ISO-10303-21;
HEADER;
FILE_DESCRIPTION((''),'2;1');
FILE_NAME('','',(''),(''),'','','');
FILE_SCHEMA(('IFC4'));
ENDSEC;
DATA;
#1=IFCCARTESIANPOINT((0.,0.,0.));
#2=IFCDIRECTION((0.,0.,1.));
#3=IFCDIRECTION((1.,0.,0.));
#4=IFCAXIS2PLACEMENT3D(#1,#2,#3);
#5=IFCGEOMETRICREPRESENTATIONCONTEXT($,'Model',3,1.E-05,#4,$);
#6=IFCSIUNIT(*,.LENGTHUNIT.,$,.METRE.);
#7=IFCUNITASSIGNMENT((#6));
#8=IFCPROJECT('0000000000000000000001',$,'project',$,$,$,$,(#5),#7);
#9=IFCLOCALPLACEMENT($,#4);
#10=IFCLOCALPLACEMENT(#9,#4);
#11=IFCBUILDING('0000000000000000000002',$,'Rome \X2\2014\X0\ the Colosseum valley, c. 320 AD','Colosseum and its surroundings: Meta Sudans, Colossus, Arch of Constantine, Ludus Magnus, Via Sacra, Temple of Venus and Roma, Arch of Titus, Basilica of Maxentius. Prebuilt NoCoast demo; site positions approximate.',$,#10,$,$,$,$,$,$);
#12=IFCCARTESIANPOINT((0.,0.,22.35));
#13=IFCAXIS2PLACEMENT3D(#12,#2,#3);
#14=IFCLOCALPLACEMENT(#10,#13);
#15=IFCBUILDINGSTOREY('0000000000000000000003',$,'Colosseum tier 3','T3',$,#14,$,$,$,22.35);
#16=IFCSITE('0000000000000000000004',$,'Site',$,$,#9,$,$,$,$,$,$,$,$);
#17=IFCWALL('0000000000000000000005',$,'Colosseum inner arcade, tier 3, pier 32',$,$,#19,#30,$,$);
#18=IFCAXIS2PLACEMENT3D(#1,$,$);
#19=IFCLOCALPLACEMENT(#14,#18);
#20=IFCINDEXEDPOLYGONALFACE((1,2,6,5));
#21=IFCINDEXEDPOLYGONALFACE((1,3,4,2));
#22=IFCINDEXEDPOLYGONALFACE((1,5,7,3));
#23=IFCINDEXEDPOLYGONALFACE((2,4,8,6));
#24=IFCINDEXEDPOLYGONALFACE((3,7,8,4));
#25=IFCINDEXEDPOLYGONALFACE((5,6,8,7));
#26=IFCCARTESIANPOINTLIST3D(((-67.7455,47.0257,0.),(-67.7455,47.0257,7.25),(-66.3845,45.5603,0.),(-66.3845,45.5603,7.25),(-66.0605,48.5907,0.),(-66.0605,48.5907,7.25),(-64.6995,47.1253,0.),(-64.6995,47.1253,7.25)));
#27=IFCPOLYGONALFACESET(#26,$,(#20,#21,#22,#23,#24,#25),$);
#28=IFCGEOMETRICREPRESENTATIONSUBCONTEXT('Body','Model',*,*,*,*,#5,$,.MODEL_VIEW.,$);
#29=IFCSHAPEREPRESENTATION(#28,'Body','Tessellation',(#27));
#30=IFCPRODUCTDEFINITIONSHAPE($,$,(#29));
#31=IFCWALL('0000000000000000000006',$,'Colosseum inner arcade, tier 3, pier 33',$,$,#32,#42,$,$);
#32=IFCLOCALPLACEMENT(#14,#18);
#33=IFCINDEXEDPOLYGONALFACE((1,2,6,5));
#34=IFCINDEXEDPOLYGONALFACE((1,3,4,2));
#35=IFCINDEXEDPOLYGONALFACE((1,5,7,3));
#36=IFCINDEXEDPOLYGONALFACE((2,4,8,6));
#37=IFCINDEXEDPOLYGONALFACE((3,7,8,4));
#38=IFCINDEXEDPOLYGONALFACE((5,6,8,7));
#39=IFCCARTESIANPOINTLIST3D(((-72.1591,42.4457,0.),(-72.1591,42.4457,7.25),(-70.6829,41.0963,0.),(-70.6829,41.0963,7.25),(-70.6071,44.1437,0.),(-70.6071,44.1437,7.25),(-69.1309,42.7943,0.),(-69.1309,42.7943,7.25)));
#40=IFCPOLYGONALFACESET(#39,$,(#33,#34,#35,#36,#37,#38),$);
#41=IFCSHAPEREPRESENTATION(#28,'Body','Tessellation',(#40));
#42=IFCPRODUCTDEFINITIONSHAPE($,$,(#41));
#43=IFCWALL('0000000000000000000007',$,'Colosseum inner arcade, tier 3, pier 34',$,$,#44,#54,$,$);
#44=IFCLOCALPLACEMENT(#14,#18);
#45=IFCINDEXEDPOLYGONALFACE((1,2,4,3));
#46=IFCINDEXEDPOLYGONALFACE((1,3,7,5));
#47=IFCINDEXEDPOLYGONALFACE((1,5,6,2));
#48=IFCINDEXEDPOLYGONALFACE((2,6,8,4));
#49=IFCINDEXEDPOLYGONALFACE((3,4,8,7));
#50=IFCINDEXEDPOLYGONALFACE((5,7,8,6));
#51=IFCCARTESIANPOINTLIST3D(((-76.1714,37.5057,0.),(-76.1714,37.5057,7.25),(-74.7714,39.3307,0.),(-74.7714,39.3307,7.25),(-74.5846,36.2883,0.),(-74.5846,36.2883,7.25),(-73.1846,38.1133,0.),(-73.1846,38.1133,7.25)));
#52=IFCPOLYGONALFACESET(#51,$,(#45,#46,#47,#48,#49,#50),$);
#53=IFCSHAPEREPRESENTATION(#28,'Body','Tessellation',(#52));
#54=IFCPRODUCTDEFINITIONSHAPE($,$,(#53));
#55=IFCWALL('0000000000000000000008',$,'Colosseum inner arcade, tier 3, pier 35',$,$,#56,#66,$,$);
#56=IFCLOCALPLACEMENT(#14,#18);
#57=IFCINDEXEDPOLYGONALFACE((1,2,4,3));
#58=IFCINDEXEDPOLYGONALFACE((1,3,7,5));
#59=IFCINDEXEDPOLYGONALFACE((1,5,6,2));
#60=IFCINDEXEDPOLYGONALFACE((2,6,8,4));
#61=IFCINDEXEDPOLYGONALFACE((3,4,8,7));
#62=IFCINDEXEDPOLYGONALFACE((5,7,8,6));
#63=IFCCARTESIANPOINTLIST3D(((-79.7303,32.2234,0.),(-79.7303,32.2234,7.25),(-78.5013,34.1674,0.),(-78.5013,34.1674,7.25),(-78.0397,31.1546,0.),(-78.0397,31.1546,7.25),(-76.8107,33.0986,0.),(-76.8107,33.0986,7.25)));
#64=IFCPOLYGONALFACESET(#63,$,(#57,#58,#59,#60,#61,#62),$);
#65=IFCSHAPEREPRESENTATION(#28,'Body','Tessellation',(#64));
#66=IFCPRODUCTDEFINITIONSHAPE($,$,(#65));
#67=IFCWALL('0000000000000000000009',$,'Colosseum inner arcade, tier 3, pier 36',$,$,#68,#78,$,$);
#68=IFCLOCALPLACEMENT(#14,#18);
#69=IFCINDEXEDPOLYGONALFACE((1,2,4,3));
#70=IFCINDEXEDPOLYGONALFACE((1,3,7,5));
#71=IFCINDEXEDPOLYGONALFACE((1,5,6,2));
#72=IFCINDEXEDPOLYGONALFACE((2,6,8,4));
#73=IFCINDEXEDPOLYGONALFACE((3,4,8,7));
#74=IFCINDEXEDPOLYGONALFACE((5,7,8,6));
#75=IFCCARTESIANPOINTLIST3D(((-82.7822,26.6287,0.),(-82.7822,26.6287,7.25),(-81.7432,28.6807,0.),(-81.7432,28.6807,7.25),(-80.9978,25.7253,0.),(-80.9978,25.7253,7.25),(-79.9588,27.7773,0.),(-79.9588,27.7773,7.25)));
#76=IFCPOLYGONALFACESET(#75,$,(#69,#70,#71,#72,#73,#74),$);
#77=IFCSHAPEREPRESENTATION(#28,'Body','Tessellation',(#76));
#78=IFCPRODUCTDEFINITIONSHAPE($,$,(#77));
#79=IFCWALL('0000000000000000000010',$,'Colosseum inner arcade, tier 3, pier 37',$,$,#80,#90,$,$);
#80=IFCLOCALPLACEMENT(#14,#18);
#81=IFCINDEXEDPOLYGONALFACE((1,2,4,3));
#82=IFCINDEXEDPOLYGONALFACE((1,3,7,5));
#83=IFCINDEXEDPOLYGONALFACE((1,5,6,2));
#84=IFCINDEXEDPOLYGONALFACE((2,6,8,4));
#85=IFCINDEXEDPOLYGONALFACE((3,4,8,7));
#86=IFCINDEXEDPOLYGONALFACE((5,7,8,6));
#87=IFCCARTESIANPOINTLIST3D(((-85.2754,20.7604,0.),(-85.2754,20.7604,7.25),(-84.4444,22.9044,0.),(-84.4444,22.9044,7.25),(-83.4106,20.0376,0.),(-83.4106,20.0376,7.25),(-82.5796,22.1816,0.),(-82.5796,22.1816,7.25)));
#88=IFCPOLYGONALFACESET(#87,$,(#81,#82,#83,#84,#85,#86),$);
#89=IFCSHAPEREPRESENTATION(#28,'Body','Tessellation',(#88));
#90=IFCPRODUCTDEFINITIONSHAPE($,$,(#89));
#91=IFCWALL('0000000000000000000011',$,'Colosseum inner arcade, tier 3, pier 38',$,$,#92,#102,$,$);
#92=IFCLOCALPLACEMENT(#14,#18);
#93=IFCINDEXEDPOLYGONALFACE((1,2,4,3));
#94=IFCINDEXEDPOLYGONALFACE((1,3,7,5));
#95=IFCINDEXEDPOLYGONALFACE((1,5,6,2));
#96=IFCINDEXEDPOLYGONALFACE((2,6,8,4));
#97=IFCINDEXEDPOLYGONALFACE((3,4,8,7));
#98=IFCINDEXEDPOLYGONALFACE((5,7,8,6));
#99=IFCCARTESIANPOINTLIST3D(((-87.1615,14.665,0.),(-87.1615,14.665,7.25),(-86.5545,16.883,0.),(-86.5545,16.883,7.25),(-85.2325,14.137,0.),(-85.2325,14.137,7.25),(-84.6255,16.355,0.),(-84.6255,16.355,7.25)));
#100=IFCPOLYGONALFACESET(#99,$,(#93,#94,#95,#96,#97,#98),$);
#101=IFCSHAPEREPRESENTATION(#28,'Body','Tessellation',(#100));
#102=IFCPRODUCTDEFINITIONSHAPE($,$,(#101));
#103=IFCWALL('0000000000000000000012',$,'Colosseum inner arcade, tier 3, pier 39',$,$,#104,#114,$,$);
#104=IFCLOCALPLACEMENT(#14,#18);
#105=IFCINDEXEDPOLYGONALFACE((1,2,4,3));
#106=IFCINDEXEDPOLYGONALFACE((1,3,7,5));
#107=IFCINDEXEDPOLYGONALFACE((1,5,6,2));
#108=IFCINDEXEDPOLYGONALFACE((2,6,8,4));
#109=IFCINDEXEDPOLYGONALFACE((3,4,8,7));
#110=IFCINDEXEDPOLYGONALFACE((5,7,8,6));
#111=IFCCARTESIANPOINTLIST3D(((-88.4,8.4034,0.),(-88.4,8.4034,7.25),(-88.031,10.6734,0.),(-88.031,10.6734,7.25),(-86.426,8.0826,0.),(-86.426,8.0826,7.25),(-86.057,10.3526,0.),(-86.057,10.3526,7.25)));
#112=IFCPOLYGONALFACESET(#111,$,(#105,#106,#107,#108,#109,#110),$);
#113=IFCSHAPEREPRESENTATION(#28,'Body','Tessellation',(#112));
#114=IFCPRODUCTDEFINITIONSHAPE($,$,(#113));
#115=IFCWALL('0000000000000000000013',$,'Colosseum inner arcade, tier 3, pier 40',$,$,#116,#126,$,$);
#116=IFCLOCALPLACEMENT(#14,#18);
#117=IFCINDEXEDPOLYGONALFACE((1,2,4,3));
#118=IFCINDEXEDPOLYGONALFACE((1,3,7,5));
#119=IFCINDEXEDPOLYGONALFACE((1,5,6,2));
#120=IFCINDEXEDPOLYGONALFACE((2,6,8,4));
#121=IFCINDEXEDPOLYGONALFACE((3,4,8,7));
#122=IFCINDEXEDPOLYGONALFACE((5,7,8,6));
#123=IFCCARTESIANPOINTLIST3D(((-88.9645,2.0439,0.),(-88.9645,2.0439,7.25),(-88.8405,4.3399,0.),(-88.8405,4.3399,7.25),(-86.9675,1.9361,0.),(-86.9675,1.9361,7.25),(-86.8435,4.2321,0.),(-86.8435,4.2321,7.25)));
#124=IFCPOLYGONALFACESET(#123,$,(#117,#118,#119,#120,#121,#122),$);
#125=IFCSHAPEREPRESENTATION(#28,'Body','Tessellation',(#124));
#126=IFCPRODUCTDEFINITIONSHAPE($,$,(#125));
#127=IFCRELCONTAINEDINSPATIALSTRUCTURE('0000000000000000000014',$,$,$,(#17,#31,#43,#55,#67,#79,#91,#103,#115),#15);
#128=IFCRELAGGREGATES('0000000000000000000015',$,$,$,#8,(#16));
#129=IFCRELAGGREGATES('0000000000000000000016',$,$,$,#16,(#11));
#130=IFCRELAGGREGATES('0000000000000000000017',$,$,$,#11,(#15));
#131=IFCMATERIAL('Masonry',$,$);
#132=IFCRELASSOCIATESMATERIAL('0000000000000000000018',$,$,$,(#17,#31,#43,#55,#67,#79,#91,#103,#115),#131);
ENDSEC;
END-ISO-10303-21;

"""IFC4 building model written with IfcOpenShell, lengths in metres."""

from ifc_helpers import new_model, si_unit, frame, origin_with_axes, place, context, subcontext, project, spatial, indexed_curve, outline, extrude, material, element, save


model = new_model("IFC4")

# Units and contexts
model_context = context("Model", 3, precision=1e-05, world=origin_with_axes())
body_context = subcontext(model_context, "Body", "Model", "MODEL_VIEW")
ifc_project = project(units=[si_unit("LENGTHUNIT", "METRE")], contexts=[model_context])

# Site, building, storey
site_placement = place(None, origin_with_axes())
site = spatial("IfcSite", under=ifc_project, at=site_placement, Name="Site")
building_placement = place(site_placement, origin_with_axes())
building = spatial("IfcBuilding", under=site, at=building_placement, Name="Rome — the Colosseum valley, c. 320 AD", Description="Colosseum and its surroundings: Meta Sudans, Colossus, Arch of Constantine, Ludus Magnus, Via Sacra, Temple of Venus and Roma, Arch of Titus, Basilica of Maxentius. Prebuilt NoCoast demo; site positions approximate.")
storey_placement = place(building_placement, frame((0.0, 0.0, 22.35), z_axis=(0.0, 0.0, 1.0), x_axis=(1.0, 0.0, 0.0)))
storey = spatial("IfcBuildingStorey", under=building, at=storey_placement, Name="Colosseum tier 3", Description="T3", Elevation=22.35)

# Walls
ifc_material = material(Name="Masonry")
wall_1_placement = place(storey_placement, frame((-65.38, 47.858, 0.0), z_axis=(0.0, 0.0, 1.0), x_axis=(-0.732716, -0.680534, 0.0)))
element("IfcWall", 1, at=wall_1_placement, inside=storey, material=ifc_material, Name="Colosseum inner arcade, tier 3, pier 32", context=body_context, shape_type="SweptSolid", body=[
    extrude(outline(indexed_curve([(0.0, 0.0), (0.0, 2.0), (2.2997, 2.0), (2.2997, 0.0), (0.0, 0.0)], self_intersect=False)), frame((0.0, -1.0, 0.0), z_axis=(0.0, 0.0, 1.0), x_axis=(1.0, 0.0, 0.0)), (0.0, 0.0, 1.0), 7.25),
])
wall_2_placement = place(storey_placement, frame((-69.869, 43.469, 0.0), z_axis=(0.0, 0.0, 1.0), x_axis=(-0.674661, -0.738128, 0.0)))
element("IfcWall", 2, at=wall_2_placement, inside=storey, material=ifc_material, Name="Colosseum inner arcade, tier 3, pier 33", context=body_context, shape_type="SweptSolid", body=[
    extrude(outline(indexed_curve([(0.0, 0.0), (0.0, 2.0), (2.3004, 2.0), (2.3004, 0.0), (0.0, 0.0)], self_intersect=False)), frame((0.0, -1.0, 0.0), z_axis=(0.0, 0.0, 1.0), x_axis=(1.0, 0.0, 0.0)), (0.0, 0.0, 1.0), 7.25),
])
wall_3_placement = place(storey_placement, frame((-73.978, 38.722, 0.0), z_axis=(0.0, 0.0, 1.0), x_axis=(-0.60866, -0.793431, 0.0)))
element("IfcWall", 3, at=wall_3_placement, inside=storey, material=ifc_material, Name="Colosseum inner arcade, tier 3, pier 34", context=body_context, shape_type="SweptSolid", body=[
    extrude(outline(indexed_curve([(0.0, 0.0), (0.0, 2.0), (2.3001, 2.0), (2.3001, 0.0), (0.0, 0.0)], self_intersect=False)), frame((0.0, -1.0, 0.0), z_axis=(0.0, 0.0, 1.0), x_axis=(1.0, 0.0, 0.0)), (0.0, 0.0, 1.0), 7.25),
])
wall_4_placement = place(storey_placement, frame((-77.656, 33.633, 0.0), z_axis=(0.0, 0.0, 1.0), x_axis=(-0.534369, -0.845251, 0.0)))
element("IfcWall", 4, at=wall_4_placement, inside=storey, material=ifc_material, Name="Colosseum inner arcade, tier 3, pier 35", context=body_context, shape_type="SweptSolid", body=[
    extrude(outline(indexed_curve([(0.0, 0.0), (0.0, 2.0), (2.2999, 2.0), (2.2999, 0.0), (0.0, 0.0)], self_intersect=False)), frame((0.0, -1.0, 0.0), z_axis=(0.0, 0.0, 1.0), x_axis=(1.0, 0.0, 0.0)), (0.0, 0.0, 1.0), 7.25),
])
wall_5_placement = place(storey_placement, frame((-80.851, 28.229, 0.0), z_axis=(0.0, 0.0, 1.0), x_axis=(-0.45173, -0.892155, 0.0)))
element("IfcWall", 5, at=wall_5_placement, inside=storey, material=ifc_material, Name="Colosseum inner arcade, tier 3, pier 36", context=body_context, shape_type="SweptSolid", body=[
    extrude(outline(indexed_curve([(0.0, 0.0), (0.0, 2.0), (2.3, 2.0), (2.3, 0.0), (0.0, 0.0)], self_intersect=False)), frame((0.0, -1.0, 0.0), z_axis=(0.0, 0.0, 1.0), x_axis=(1.0, 0.0, 0.0)), (0.0, 0.0, 1.0), 7.25),
])
wall_6_placement = place(storey_placement, frame((-83.512, 22.543, 0.0), z_axis=(0.0, 0.0, 1.0), x_axis=(-0.361397, -0.932412, 0.0)))
element("IfcWall", 6, at=wall_6_placement, inside=storey, material=ifc_material, Name="Colosseum inner arcade, tier 3, pier 37", context=body_context, shape_type="SweptSolid", body=[
    extrude(outline(indexed_curve([(0.0, 0.0), (0.0, 2.0), (2.2994, 2.0), (2.2994, 0.0), (0.0, 0.0)], self_intersect=False)), frame((0.0, -1.0, 0.0), z_axis=(0.0, 0.0, 1.0), x_axis=(1.0, 0.0, 0.0)), (0.0, 0.0, 1.0), 7.25),
])
wall_7_placement = place(storey_placement, frame((-85.59, 16.619, 0.0), z_axis=(0.0, 0.0, 1.0), x_axis=(-0.263964, -0.964533, 0.0)))
element("IfcWall", 7, at=wall_7_placement, inside=storey, material=ifc_material, Name="Colosseum inner arcade, tier 3, pier 38", context=body_context, shape_type="SweptSolid", body=[
    extrude(outline(indexed_curve([(0.0, 0.0), (0.0, 2.0), (2.2996, 2.0), (2.2996, 0.0), (0.0, 0.0)], self_intersect=False)), frame((0.0, -1.0, 0.0), z_axis=(0.0, 0.0, 1.0), x_axis=(1.0, 0.0, 0.0)), (0.0, 0.0, 1.0), 7.25),
])
wall_8_placement = place(storey_placement, frame((-87.044, 10.513, 0.0), z_axis=(0.0, 0.0, 1.0), x_axis=(-0.160449, -0.987044, 0.0)))
element("IfcWall", 8, at=wall_8_placement, inside=storey, material=ifc_material, Name="Colosseum inner arcade, tier 3, pier 39", context=body_context, shape_type="SweptSolid", body=[
    extrude(outline(indexed_curve([(0.0, 0.0), (0.0, 2.0), (2.2998, 2.0), (2.2998, 0.0), (0.0, 0.0)], self_intersect=False)), frame((0.0, -1.0, 0.0), z_axis=(0.0, 0.0, 1.0), x_axis=(1.0, 0.0, 0.0)), (0.0, 0.0, 1.0), 7.25),
])
wall_9_placement = place(storey_placement, frame((-87.842, 4.286, 0.0), z_axis=(0.0, 0.0, 1.0), x_axis=(-0.053928, -0.998545, 0.0)))
element("IfcWall", 9, at=wall_9_placement, inside=storey, material=ifc_material, Name="Colosseum inner arcade, tier 3, pier 40", context=body_context, shape_type="SweptSolid", body=[
    extrude(outline(indexed_curve([(0.0, 0.0), (0.0, 2.0), (2.2993, 2.0), (2.2993, 0.0), (0.0, 0.0)], self_intersect=False)), frame((0.0, -1.0, 0.0), z_axis=(0.0, 0.0, 1.0), x_axis=(1.0, 0.0, 0.0)), (0.0, 0.0, 1.0), 7.25),
])

save(model, "model.ifc")
